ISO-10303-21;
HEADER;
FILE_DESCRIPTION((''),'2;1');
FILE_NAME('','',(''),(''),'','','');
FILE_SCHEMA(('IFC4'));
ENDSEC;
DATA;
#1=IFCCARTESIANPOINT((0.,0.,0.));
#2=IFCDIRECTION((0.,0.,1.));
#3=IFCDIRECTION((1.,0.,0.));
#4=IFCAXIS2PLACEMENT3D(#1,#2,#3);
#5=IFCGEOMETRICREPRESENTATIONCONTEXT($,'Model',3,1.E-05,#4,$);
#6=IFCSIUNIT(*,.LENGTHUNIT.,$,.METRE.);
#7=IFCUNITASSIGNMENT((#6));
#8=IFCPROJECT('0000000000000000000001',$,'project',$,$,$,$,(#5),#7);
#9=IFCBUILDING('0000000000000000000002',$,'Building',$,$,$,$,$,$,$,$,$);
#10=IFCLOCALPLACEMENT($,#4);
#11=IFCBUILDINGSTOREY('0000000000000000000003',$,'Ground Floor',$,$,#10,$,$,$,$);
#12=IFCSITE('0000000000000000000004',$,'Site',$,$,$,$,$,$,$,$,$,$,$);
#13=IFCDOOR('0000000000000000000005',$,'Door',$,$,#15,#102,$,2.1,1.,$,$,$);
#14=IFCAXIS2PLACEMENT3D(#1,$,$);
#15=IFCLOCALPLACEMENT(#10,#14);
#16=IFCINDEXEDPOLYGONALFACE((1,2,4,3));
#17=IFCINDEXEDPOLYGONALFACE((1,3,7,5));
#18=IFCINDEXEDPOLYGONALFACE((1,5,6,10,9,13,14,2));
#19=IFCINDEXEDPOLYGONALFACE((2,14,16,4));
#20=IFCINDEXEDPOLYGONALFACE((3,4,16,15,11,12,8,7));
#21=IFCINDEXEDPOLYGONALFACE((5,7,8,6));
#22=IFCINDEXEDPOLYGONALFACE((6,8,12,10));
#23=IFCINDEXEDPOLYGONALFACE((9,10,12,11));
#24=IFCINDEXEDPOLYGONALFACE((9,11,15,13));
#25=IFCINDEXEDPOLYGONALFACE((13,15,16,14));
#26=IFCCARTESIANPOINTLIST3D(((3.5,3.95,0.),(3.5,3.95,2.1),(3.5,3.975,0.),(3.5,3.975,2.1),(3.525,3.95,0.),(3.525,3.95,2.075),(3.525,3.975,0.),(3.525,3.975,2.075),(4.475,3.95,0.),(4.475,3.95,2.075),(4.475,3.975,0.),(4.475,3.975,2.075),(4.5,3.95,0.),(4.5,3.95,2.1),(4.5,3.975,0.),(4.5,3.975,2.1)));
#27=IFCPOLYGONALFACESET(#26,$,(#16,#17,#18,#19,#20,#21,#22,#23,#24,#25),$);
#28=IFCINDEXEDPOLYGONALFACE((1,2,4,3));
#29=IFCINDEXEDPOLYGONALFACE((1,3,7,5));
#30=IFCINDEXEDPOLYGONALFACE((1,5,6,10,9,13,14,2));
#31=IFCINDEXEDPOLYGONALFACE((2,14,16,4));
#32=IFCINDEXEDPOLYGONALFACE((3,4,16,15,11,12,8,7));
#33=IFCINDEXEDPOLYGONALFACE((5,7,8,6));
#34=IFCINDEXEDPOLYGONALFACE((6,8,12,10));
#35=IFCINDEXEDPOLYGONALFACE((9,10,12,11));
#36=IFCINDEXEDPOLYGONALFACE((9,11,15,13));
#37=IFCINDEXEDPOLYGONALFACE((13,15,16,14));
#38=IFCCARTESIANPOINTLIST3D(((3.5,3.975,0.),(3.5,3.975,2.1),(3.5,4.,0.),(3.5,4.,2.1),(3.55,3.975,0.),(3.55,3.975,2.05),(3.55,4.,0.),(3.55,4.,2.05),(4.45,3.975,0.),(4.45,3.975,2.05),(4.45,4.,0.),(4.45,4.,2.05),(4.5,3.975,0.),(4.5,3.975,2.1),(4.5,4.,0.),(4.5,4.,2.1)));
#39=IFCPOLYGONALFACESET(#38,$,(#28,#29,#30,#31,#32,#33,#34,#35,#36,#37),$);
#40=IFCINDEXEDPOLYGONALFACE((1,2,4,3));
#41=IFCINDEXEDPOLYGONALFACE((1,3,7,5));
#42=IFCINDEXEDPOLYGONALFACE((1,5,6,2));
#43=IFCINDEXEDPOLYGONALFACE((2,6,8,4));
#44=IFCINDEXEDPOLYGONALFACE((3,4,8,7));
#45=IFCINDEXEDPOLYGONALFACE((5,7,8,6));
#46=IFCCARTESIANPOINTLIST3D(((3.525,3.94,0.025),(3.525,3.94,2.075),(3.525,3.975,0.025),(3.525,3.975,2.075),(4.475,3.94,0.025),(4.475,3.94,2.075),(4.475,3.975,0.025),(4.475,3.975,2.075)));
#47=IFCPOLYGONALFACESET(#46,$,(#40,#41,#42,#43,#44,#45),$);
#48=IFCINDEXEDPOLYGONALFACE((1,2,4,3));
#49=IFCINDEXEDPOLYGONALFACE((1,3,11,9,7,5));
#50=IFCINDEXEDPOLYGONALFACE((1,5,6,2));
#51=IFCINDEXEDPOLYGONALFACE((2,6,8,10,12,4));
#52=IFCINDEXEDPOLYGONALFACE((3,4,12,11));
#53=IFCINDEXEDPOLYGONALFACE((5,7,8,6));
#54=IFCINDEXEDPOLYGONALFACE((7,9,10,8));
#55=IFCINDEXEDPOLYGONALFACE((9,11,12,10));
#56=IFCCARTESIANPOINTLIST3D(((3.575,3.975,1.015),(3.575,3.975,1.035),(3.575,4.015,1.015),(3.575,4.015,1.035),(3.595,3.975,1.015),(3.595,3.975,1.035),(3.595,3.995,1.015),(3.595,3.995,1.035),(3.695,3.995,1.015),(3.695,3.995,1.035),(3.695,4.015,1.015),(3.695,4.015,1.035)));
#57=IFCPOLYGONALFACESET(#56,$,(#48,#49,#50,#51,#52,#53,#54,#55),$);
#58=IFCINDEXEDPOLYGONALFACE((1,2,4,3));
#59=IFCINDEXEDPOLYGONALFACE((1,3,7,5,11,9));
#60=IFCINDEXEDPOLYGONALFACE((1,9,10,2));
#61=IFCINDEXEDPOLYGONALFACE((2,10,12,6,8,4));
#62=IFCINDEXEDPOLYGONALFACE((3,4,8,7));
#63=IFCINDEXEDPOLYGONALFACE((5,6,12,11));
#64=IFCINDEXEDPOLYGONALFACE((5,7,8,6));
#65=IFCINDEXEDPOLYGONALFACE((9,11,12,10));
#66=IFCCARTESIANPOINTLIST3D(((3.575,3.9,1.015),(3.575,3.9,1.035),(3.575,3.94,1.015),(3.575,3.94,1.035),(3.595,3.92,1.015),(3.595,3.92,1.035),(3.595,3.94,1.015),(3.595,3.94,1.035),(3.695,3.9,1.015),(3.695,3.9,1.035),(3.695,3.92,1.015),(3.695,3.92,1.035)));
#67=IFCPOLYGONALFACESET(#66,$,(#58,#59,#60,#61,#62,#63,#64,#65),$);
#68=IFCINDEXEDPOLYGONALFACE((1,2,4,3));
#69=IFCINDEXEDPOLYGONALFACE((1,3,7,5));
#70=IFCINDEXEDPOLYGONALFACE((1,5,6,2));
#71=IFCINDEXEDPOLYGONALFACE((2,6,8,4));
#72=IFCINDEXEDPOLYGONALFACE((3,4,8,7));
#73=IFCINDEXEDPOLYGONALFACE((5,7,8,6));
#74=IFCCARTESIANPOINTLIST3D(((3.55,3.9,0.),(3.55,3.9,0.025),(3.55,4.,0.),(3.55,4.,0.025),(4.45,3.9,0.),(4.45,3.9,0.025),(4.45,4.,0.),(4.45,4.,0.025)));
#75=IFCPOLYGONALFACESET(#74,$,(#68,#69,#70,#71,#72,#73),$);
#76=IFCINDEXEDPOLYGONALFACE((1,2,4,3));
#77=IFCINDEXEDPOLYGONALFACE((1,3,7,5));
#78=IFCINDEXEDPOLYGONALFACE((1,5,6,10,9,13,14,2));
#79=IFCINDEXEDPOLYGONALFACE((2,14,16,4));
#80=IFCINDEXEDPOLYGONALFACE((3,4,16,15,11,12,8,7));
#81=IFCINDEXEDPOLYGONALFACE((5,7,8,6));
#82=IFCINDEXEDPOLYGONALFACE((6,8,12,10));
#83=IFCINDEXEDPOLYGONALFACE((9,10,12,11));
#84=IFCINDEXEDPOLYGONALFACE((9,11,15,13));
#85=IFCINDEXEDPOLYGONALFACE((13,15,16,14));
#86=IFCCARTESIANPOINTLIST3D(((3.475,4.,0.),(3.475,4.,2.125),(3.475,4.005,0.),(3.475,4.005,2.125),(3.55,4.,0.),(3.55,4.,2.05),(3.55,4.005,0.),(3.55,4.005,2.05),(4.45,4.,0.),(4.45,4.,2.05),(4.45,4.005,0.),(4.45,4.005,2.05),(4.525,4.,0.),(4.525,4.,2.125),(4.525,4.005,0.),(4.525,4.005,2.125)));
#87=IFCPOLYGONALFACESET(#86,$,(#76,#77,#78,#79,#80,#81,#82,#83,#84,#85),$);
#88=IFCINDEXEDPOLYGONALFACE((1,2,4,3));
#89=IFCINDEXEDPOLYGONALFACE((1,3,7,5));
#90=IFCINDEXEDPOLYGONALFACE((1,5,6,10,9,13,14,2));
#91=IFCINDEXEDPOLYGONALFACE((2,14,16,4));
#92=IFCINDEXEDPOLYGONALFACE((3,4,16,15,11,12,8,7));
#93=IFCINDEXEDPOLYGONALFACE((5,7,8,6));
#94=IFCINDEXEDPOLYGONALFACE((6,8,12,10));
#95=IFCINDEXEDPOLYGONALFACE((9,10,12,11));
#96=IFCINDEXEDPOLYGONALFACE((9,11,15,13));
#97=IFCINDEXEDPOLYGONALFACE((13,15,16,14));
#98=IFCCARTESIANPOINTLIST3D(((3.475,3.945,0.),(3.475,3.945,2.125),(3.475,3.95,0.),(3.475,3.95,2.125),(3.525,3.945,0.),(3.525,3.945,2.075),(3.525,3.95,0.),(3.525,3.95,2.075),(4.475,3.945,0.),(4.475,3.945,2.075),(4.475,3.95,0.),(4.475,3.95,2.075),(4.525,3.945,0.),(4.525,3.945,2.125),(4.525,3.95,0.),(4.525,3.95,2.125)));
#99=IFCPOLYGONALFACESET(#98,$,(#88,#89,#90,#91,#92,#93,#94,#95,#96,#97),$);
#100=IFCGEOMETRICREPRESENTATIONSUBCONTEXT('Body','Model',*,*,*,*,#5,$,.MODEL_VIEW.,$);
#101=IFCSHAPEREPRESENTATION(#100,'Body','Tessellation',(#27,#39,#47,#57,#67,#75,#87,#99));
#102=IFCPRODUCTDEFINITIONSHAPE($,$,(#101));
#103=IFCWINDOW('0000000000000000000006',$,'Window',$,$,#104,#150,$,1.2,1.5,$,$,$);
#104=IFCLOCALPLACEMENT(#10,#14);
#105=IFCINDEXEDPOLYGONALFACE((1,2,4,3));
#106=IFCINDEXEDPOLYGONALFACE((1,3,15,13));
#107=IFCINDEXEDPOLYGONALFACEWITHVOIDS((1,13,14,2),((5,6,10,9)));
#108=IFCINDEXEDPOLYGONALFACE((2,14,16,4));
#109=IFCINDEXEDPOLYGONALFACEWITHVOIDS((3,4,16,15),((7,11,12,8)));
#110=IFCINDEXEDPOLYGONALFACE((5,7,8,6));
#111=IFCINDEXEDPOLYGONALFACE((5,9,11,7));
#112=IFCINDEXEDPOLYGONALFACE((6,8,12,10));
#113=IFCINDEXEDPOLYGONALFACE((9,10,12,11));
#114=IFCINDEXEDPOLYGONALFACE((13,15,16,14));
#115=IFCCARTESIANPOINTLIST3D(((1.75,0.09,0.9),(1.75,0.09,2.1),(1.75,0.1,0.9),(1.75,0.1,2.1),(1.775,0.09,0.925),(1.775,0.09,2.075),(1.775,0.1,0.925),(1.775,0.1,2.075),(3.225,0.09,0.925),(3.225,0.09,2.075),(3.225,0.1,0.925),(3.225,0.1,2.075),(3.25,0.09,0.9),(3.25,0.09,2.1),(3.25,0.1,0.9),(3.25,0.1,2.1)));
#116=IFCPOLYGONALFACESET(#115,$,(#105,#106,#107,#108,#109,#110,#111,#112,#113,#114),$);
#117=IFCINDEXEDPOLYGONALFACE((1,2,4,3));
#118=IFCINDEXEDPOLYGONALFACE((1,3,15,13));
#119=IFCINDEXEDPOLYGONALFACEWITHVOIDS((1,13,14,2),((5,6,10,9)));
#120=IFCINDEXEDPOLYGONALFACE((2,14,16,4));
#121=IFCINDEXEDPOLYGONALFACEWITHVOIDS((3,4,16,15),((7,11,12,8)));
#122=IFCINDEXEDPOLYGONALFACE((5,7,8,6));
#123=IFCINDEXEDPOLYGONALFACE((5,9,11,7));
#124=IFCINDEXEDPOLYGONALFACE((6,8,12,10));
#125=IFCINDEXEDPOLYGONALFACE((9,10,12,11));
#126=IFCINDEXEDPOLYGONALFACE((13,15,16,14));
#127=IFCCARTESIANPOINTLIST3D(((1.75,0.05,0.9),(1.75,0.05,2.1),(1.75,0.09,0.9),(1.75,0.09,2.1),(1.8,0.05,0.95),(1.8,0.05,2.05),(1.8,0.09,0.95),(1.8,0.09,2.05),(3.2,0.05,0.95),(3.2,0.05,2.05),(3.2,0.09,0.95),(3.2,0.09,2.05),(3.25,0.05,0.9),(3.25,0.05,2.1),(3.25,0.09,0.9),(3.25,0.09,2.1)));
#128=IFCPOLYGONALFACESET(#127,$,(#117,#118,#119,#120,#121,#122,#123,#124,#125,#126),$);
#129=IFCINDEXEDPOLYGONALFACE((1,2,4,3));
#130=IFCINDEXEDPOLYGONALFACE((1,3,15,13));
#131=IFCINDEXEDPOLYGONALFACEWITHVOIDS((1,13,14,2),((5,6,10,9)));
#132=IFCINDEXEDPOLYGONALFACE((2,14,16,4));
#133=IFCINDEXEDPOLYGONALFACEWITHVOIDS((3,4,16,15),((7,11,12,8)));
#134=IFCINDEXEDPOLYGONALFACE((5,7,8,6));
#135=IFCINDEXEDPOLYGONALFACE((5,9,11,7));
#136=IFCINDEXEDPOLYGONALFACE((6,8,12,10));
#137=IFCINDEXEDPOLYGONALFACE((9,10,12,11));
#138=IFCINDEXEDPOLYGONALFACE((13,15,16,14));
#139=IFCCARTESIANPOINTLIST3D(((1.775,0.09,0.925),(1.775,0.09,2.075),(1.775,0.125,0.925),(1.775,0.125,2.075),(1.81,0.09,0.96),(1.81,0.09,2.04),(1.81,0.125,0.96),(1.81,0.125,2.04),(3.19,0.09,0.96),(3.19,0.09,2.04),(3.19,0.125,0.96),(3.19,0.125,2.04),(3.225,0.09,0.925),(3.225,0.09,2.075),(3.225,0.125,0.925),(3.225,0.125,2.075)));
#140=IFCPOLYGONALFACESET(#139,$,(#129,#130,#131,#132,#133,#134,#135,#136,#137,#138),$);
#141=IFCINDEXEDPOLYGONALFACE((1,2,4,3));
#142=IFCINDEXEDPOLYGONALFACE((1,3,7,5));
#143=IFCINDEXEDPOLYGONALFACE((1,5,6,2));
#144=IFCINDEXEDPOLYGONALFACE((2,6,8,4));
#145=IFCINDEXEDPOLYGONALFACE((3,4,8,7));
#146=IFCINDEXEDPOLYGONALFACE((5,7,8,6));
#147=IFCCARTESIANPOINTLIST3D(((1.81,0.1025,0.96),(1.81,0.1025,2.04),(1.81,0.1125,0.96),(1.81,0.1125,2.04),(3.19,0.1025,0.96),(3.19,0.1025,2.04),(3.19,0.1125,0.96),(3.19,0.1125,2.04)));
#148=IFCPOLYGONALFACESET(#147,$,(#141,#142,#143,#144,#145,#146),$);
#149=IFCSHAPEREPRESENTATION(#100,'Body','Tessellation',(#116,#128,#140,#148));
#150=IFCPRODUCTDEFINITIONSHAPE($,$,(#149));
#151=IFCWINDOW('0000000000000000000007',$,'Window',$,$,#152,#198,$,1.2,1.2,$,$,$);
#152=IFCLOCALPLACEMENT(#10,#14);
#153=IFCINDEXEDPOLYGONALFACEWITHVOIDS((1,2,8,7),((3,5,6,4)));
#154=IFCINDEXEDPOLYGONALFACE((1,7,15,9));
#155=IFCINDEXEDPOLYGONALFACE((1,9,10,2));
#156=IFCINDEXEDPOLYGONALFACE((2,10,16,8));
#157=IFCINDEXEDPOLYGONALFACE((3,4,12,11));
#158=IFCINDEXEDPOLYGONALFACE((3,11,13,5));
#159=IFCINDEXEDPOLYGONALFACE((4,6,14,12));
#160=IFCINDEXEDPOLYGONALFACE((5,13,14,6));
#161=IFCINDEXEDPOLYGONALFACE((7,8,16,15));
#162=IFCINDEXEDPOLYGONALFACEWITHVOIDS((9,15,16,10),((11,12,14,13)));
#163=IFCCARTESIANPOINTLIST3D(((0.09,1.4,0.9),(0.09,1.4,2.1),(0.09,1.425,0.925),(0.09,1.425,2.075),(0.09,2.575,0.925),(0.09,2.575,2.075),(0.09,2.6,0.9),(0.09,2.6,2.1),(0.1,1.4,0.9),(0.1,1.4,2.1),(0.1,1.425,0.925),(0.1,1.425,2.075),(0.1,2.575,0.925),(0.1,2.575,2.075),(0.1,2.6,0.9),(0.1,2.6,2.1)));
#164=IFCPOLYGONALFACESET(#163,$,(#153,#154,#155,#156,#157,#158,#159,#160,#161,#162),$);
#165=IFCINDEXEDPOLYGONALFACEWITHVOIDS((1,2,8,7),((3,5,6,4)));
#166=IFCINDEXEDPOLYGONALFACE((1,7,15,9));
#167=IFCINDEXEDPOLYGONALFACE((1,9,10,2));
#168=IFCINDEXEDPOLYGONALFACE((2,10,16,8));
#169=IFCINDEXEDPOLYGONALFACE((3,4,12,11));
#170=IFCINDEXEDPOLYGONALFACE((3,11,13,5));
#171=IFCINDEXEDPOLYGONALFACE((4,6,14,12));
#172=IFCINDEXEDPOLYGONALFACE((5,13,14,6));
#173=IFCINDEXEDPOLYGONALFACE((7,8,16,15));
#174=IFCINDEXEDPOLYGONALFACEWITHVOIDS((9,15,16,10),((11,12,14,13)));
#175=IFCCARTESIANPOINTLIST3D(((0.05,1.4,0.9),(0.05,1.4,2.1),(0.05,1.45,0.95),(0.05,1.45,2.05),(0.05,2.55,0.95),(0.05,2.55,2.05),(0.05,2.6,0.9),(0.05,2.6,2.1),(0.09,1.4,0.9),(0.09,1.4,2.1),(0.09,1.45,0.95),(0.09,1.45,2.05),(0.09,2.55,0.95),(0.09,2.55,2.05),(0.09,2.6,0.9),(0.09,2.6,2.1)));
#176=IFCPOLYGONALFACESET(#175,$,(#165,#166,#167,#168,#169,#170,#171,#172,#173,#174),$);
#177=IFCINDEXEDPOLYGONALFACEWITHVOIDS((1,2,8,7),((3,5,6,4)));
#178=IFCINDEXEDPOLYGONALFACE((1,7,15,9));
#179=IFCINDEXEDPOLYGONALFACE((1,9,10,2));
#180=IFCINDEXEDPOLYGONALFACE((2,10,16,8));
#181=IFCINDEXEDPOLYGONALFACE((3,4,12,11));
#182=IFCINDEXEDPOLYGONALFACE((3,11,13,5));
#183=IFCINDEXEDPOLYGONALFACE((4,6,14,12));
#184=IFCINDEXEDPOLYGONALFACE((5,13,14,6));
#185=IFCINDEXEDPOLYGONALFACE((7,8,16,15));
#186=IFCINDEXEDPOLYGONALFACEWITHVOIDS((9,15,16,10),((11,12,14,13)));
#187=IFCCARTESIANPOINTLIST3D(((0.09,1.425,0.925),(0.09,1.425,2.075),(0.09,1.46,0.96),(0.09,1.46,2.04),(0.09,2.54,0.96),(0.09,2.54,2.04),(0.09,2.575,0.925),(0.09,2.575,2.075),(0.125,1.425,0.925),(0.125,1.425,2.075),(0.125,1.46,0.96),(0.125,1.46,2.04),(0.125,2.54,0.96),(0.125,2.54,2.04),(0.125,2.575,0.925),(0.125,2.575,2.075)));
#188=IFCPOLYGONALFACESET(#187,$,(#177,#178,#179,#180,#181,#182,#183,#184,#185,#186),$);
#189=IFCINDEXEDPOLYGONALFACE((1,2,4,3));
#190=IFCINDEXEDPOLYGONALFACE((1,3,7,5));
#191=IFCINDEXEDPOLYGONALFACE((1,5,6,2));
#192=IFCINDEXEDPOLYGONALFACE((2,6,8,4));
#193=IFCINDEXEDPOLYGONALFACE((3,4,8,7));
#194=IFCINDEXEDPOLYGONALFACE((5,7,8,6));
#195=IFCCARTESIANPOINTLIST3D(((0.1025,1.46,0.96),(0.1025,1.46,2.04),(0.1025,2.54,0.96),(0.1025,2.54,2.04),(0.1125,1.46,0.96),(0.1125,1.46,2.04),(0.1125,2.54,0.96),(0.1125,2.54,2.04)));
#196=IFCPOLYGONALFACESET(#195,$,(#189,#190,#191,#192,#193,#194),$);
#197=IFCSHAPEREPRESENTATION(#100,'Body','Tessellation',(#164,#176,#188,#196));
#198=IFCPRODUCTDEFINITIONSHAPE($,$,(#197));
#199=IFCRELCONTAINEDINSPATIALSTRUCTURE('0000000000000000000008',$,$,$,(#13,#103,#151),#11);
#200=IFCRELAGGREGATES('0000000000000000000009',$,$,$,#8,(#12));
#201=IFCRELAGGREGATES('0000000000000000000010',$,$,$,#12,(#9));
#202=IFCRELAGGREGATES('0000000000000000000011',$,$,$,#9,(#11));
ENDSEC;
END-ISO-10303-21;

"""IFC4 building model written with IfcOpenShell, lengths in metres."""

from ifc_helpers import new_model, si_unit, frame, origin_with_axes, place, context, subcontext, project, spatial, line, indexed_curve, outline, extrude, element, save


model = new_model("IFC4")

# Units and contexts
model_context = context("Model", 3, precision=1e-05, world=origin_with_axes())
body_context = subcontext(model_context, "Body", "Model", "MODEL_VIEW")
ifc_project = project(units=[si_unit("LENGTHUNIT", "METRE")], contexts=[model_context])

# Site, building, storey
site = spatial("IfcSite", under=ifc_project, Name="Site")
building = spatial("IfcBuilding", under=site, Name="Building")
storey_placement = place(None, origin_with_axes())
storey = spatial("IfcBuildingStorey", under=building, at=storey_placement, Name="Ground Floor")

# Door
door_1_placement = place(storey_placement, frame((4.5, 4.0, 0.0), z_axis=(0.0, 0.0, 1.0), x_axis=(-1.0, 0.0, 0.0)))
element("IfcDoor", 1, at=door_1_placement, inside=storey, Name="Door", OverallHeight=2.1, OverallWidth=1.0, context=body_context, shape_type="SweptSolid", body=[
    extrude(outline(indexed_curve([(0.0, 0.0), (0.0, 2.1), (1.0, 2.1), (1.0, 0.0), (0.975, 0.0), (0.975, 2.075), (0.025, 2.075), (0.025, 0.0)], segments=[line(1, 2, 3, 4, 5, 6, 7, 8, 1)])), frame((0.0, 0.025, 0.0), z_axis=(0.0, -1.0, 0.0), x_axis=(1.0, 0.0, 0.0)), (0.0, 0.0, -1.0), 0.025),
    extrude(outline(indexed_curve([(0.0, 0.0), (0.0, 2.1), (1.0, 2.1), (1.0, 0.0), (0.95, 0.0), (0.95, 2.05), (0.05, 2.05), (0.05, 0.0)], segments=[line(1, 2, 3, 4, 5, 6, 7, 8, 1)])), frame((0.0, 0.0, 0.0), z_axis=(0.0, -1.0, 0.0), x_axis=(1.0, 0.0, 0.0)), (0.0, 0.0, -1.0), 0.025),
    extrude(outline(indexed_curve([(0.0, 0.0), (0.95, 0.0), (0.95, 0.035), (0.0, 0.035)], segments=[line(1, 2, 3, 4, 1)])), frame((0.025, 0.025, 0.025), z_axis=(0.0, 0.0, 1.0), x_axis=(1.0, 0.0, 0.0)), (0.0, 0.0, 1.0), 2.05),
    extrude(outline(indexed_curve([(0.0, 0.0), (0.0, -0.04), (-0.12, -0.04), (-0.12, -0.02), (-0.02, -0.02), (-0.02, 0.0)], segments=[line(1, 2, 3, 4, 5, 6, 1)])), frame((0.925, 0.025, 1.015), z_axis=(0.0, 0.0, 1.0), x_axis=(1.0, 0.0, 0.0)), (0.0, 0.0, 1.0), 0.02),
    extrude(outline(indexed_curve([(0.0, 0.0), (0.0, 0.04), (-0.12, 0.04), (-0.12, 0.02), (-0.02, 0.02), (-0.02, 0.0)], segments=[line(1, 2, 3, 4, 5, 6, 1)])), frame((0.925, 0.06, 1.015), z_axis=(0.0, 0.0, 1.0), x_axis=(1.0, 0.0, 0.0)), (0.0, 0.0, 1.0), 0.02),
    extrude(outline(indexed_curve([(0.0, 0.0), (0.9, 0.0), (0.9, 0.1), (0.0, 0.1)], segments=[line(1, 2, 3, 4, 1)])), frame((0.05, 0.0, 0.0), z_axis=(0.0, 0.0, 1.0), x_axis=(1.0, 0.0, 0.0)), (0.0, 0.0, 1.0), 0.025),
    extrude(outline(indexed_curve([(0.0, 0.0), (0.0, 2.125), (1.05, 2.125), (1.05, 0.0), (0.975, 0.0), (0.975, 2.05), (0.075, 2.05), (0.075, 0.0)], segments=[line(1, 2, 3, 4, 5, 6, 7, 8, 1)])), frame((-0.025, -0.005, 0.0), z_axis=(0.0, -1.0, 0.0), x_axis=(1.0, 0.0, 0.0)), (0.0, 0.0, -1.0), 0.005),
    extrude(outline(indexed_curve([(0.0, 0.0), (0.0, 2.125), (1.05, 2.125), (1.05, 0.0), (1.0, 0.0), (1.0, 2.075), (0.05, 2.075), (0.05, 0.0)], segments=[line(1, 2, 3, 4, 5, 6, 7, 8, 1)])), frame((-0.025, 0.05, 0.0), z_axis=(0.0, -1.0, 0.0), x_axis=(1.0, 0.0, 0.0)), (0.0, 0.0, -1.0), 0.005),
])

# Windows
window_placement = place(storey_placement, frame((1.75, 0.0, 0.9), z_axis=(0.0, 0.0, 1.0), x_axis=(1.0, 0.0, 0.0)))
element("IfcWindow", 2, at=window_placement, inside=storey, Name="Window", OverallHeight=1.2, OverallWidth=1.5, context=body_context, shape_type="SweptSolid", body=[
    extrude(outline(indexed_curve([(0.0, 0.0), (1.5, 0.0), (1.5, 1.2), (0.0, 1.2)], segments=[line(1, 2, 3, 4, 1)]), holes=[indexed_curve([(0.025, 0.025), (1.475, 0.025), (1.475, 1.175), (0.025, 1.175)], segments=[line(1, 2, 3, 4, 1)])]), frame((0.0, 0.09, 0.0), z_axis=(0.0, -1.0, 0.0), x_axis=(1.0, 0.0, 0.0)), (0.0, 0.0, -1.0), 0.01),
    extrude(outline(indexed_curve([(0.0, 0.0), (1.5, 0.0), (1.5, 1.2), (0.0, 1.2)], segments=[line(1, 2, 3, 4, 1)]), holes=[indexed_curve([(0.05, 0.05), (1.45, 0.05), (1.45, 1.15), (0.05, 1.15)], segments=[line(1, 2, 3, 4, 1)])]), frame((0.0, 0.05, 0.0), z_axis=(0.0, -1.0, 0.0), x_axis=(1.0, 0.0, 0.0)), (0.0, 0.0, -1.0), 0.04),
    extrude(outline(indexed_curve([(0.0, 0.0), (1.45, 0.0), (1.45, 1.15), (0.0, 1.15)], segments=[line(1, 2, 3, 4, 1)]), holes=[indexed_curve([(0.035, 0.035), (1.415, 0.035), (1.415, 1.115), (0.035, 1.115)], segments=[line(1, 2, 3, 4, 1)])]), frame((0.025, 0.09, 0.025), z_axis=(0.0, -1.0, 0.0), x_axis=(1.0, 0.0, 0.0)), (0.0, 0.0, -1.0), 0.035),
    extrude(outline(indexed_curve([(0.035, 0.035), (1.415, 0.035), (1.415, 1.115), (0.035, 1.115)], segments=[line(1, 2, 3, 4, 1)])), frame((0.025, 0.1025, 0.025), z_axis=(0.0, -1.0, 0.0), x_axis=(1.0, 0.0, 0.0)), (0.0, 0.0, -1.0), 0.01),
])
for number, where, z_axis, x_axis, name in (
    (3, (0.0, 2.6, 0.9), (0.0, 0.0, 1.0), (0.0, -1.0, 0.0), "Window"),
):
    element("IfcWindow", number, at=place(storey_placement, frame(where, z_axis=z_axis, x_axis=x_axis)), inside=storey, Name=name, OverallHeight=1.2, OverallWidth=1.2, context=body_context, shape_type="SweptSolid", body=[
        extrude(outline(indexed_curve([(0.0, 0.0), (1.2, 0.0), (1.2, 1.2), (0.0, 1.2)], segments=[line(1, 2, 3, 4, 1)]), holes=[indexed_curve([(0.025, 0.025), (1.175, 0.025), (1.175, 1.175), (0.025, 1.175)], segments=[line(1, 2, 3, 4, 1)])]), frame((0.0, 0.09, 0.0), z_axis=(0.0, -1.0, 0.0), x_axis=(1.0, 0.0, 0.0)), (0.0, 0.0, -1.0), 0.01),
        extrude(outline(indexed_curve([(0.0, 0.0), (1.2, 0.0), (1.2, 1.2), (0.0, 1.2)], segments=[line(1, 2, 3, 4, 1)]), holes=[indexed_curve([(0.05, 0.05), (1.15, 0.05), (1.15, 1.15), (0.05, 1.15)], segments=[line(1, 2, 3, 4, 1)])]), frame((0.0, 0.05, 0.0), z_axis=(0.0, -1.0, 0.0), x_axis=(1.0, 0.0, 0.0)), (0.0, 0.0, -1.0), 0.04),
        extrude(outline(indexed_curve([(0.0, 0.0), (1.15, 0.0), (1.15, 1.15), (0.0, 1.15)], segments=[line(1, 2, 3, 4, 1)]), holes=[indexed_curve([(0.035, 0.035), (1.115, 0.035), (1.115, 1.115), (0.035, 1.115)], segments=[line(1, 2, 3, 4, 1)])]), frame((0.025, 0.09, 0.025), z_axis=(0.0, -1.0, 0.0), x_axis=(1.0, 0.0, 0.0)), (0.0, 0.0, -1.0), 0.035),
        extrude(outline(indexed_curve([(0.035, 0.035), (1.115, 0.035), (1.115, 1.115), (0.035, 1.115)], segments=[line(1, 2, 3, 4, 1)])), frame((0.025, 0.1025, 0.025), z_axis=(0.0, -1.0, 0.0), x_axis=(1.0, 0.0, 0.0)), (0.0, 0.0, -1.0), 0.01),
    ])

save(model, "model.ifc")
